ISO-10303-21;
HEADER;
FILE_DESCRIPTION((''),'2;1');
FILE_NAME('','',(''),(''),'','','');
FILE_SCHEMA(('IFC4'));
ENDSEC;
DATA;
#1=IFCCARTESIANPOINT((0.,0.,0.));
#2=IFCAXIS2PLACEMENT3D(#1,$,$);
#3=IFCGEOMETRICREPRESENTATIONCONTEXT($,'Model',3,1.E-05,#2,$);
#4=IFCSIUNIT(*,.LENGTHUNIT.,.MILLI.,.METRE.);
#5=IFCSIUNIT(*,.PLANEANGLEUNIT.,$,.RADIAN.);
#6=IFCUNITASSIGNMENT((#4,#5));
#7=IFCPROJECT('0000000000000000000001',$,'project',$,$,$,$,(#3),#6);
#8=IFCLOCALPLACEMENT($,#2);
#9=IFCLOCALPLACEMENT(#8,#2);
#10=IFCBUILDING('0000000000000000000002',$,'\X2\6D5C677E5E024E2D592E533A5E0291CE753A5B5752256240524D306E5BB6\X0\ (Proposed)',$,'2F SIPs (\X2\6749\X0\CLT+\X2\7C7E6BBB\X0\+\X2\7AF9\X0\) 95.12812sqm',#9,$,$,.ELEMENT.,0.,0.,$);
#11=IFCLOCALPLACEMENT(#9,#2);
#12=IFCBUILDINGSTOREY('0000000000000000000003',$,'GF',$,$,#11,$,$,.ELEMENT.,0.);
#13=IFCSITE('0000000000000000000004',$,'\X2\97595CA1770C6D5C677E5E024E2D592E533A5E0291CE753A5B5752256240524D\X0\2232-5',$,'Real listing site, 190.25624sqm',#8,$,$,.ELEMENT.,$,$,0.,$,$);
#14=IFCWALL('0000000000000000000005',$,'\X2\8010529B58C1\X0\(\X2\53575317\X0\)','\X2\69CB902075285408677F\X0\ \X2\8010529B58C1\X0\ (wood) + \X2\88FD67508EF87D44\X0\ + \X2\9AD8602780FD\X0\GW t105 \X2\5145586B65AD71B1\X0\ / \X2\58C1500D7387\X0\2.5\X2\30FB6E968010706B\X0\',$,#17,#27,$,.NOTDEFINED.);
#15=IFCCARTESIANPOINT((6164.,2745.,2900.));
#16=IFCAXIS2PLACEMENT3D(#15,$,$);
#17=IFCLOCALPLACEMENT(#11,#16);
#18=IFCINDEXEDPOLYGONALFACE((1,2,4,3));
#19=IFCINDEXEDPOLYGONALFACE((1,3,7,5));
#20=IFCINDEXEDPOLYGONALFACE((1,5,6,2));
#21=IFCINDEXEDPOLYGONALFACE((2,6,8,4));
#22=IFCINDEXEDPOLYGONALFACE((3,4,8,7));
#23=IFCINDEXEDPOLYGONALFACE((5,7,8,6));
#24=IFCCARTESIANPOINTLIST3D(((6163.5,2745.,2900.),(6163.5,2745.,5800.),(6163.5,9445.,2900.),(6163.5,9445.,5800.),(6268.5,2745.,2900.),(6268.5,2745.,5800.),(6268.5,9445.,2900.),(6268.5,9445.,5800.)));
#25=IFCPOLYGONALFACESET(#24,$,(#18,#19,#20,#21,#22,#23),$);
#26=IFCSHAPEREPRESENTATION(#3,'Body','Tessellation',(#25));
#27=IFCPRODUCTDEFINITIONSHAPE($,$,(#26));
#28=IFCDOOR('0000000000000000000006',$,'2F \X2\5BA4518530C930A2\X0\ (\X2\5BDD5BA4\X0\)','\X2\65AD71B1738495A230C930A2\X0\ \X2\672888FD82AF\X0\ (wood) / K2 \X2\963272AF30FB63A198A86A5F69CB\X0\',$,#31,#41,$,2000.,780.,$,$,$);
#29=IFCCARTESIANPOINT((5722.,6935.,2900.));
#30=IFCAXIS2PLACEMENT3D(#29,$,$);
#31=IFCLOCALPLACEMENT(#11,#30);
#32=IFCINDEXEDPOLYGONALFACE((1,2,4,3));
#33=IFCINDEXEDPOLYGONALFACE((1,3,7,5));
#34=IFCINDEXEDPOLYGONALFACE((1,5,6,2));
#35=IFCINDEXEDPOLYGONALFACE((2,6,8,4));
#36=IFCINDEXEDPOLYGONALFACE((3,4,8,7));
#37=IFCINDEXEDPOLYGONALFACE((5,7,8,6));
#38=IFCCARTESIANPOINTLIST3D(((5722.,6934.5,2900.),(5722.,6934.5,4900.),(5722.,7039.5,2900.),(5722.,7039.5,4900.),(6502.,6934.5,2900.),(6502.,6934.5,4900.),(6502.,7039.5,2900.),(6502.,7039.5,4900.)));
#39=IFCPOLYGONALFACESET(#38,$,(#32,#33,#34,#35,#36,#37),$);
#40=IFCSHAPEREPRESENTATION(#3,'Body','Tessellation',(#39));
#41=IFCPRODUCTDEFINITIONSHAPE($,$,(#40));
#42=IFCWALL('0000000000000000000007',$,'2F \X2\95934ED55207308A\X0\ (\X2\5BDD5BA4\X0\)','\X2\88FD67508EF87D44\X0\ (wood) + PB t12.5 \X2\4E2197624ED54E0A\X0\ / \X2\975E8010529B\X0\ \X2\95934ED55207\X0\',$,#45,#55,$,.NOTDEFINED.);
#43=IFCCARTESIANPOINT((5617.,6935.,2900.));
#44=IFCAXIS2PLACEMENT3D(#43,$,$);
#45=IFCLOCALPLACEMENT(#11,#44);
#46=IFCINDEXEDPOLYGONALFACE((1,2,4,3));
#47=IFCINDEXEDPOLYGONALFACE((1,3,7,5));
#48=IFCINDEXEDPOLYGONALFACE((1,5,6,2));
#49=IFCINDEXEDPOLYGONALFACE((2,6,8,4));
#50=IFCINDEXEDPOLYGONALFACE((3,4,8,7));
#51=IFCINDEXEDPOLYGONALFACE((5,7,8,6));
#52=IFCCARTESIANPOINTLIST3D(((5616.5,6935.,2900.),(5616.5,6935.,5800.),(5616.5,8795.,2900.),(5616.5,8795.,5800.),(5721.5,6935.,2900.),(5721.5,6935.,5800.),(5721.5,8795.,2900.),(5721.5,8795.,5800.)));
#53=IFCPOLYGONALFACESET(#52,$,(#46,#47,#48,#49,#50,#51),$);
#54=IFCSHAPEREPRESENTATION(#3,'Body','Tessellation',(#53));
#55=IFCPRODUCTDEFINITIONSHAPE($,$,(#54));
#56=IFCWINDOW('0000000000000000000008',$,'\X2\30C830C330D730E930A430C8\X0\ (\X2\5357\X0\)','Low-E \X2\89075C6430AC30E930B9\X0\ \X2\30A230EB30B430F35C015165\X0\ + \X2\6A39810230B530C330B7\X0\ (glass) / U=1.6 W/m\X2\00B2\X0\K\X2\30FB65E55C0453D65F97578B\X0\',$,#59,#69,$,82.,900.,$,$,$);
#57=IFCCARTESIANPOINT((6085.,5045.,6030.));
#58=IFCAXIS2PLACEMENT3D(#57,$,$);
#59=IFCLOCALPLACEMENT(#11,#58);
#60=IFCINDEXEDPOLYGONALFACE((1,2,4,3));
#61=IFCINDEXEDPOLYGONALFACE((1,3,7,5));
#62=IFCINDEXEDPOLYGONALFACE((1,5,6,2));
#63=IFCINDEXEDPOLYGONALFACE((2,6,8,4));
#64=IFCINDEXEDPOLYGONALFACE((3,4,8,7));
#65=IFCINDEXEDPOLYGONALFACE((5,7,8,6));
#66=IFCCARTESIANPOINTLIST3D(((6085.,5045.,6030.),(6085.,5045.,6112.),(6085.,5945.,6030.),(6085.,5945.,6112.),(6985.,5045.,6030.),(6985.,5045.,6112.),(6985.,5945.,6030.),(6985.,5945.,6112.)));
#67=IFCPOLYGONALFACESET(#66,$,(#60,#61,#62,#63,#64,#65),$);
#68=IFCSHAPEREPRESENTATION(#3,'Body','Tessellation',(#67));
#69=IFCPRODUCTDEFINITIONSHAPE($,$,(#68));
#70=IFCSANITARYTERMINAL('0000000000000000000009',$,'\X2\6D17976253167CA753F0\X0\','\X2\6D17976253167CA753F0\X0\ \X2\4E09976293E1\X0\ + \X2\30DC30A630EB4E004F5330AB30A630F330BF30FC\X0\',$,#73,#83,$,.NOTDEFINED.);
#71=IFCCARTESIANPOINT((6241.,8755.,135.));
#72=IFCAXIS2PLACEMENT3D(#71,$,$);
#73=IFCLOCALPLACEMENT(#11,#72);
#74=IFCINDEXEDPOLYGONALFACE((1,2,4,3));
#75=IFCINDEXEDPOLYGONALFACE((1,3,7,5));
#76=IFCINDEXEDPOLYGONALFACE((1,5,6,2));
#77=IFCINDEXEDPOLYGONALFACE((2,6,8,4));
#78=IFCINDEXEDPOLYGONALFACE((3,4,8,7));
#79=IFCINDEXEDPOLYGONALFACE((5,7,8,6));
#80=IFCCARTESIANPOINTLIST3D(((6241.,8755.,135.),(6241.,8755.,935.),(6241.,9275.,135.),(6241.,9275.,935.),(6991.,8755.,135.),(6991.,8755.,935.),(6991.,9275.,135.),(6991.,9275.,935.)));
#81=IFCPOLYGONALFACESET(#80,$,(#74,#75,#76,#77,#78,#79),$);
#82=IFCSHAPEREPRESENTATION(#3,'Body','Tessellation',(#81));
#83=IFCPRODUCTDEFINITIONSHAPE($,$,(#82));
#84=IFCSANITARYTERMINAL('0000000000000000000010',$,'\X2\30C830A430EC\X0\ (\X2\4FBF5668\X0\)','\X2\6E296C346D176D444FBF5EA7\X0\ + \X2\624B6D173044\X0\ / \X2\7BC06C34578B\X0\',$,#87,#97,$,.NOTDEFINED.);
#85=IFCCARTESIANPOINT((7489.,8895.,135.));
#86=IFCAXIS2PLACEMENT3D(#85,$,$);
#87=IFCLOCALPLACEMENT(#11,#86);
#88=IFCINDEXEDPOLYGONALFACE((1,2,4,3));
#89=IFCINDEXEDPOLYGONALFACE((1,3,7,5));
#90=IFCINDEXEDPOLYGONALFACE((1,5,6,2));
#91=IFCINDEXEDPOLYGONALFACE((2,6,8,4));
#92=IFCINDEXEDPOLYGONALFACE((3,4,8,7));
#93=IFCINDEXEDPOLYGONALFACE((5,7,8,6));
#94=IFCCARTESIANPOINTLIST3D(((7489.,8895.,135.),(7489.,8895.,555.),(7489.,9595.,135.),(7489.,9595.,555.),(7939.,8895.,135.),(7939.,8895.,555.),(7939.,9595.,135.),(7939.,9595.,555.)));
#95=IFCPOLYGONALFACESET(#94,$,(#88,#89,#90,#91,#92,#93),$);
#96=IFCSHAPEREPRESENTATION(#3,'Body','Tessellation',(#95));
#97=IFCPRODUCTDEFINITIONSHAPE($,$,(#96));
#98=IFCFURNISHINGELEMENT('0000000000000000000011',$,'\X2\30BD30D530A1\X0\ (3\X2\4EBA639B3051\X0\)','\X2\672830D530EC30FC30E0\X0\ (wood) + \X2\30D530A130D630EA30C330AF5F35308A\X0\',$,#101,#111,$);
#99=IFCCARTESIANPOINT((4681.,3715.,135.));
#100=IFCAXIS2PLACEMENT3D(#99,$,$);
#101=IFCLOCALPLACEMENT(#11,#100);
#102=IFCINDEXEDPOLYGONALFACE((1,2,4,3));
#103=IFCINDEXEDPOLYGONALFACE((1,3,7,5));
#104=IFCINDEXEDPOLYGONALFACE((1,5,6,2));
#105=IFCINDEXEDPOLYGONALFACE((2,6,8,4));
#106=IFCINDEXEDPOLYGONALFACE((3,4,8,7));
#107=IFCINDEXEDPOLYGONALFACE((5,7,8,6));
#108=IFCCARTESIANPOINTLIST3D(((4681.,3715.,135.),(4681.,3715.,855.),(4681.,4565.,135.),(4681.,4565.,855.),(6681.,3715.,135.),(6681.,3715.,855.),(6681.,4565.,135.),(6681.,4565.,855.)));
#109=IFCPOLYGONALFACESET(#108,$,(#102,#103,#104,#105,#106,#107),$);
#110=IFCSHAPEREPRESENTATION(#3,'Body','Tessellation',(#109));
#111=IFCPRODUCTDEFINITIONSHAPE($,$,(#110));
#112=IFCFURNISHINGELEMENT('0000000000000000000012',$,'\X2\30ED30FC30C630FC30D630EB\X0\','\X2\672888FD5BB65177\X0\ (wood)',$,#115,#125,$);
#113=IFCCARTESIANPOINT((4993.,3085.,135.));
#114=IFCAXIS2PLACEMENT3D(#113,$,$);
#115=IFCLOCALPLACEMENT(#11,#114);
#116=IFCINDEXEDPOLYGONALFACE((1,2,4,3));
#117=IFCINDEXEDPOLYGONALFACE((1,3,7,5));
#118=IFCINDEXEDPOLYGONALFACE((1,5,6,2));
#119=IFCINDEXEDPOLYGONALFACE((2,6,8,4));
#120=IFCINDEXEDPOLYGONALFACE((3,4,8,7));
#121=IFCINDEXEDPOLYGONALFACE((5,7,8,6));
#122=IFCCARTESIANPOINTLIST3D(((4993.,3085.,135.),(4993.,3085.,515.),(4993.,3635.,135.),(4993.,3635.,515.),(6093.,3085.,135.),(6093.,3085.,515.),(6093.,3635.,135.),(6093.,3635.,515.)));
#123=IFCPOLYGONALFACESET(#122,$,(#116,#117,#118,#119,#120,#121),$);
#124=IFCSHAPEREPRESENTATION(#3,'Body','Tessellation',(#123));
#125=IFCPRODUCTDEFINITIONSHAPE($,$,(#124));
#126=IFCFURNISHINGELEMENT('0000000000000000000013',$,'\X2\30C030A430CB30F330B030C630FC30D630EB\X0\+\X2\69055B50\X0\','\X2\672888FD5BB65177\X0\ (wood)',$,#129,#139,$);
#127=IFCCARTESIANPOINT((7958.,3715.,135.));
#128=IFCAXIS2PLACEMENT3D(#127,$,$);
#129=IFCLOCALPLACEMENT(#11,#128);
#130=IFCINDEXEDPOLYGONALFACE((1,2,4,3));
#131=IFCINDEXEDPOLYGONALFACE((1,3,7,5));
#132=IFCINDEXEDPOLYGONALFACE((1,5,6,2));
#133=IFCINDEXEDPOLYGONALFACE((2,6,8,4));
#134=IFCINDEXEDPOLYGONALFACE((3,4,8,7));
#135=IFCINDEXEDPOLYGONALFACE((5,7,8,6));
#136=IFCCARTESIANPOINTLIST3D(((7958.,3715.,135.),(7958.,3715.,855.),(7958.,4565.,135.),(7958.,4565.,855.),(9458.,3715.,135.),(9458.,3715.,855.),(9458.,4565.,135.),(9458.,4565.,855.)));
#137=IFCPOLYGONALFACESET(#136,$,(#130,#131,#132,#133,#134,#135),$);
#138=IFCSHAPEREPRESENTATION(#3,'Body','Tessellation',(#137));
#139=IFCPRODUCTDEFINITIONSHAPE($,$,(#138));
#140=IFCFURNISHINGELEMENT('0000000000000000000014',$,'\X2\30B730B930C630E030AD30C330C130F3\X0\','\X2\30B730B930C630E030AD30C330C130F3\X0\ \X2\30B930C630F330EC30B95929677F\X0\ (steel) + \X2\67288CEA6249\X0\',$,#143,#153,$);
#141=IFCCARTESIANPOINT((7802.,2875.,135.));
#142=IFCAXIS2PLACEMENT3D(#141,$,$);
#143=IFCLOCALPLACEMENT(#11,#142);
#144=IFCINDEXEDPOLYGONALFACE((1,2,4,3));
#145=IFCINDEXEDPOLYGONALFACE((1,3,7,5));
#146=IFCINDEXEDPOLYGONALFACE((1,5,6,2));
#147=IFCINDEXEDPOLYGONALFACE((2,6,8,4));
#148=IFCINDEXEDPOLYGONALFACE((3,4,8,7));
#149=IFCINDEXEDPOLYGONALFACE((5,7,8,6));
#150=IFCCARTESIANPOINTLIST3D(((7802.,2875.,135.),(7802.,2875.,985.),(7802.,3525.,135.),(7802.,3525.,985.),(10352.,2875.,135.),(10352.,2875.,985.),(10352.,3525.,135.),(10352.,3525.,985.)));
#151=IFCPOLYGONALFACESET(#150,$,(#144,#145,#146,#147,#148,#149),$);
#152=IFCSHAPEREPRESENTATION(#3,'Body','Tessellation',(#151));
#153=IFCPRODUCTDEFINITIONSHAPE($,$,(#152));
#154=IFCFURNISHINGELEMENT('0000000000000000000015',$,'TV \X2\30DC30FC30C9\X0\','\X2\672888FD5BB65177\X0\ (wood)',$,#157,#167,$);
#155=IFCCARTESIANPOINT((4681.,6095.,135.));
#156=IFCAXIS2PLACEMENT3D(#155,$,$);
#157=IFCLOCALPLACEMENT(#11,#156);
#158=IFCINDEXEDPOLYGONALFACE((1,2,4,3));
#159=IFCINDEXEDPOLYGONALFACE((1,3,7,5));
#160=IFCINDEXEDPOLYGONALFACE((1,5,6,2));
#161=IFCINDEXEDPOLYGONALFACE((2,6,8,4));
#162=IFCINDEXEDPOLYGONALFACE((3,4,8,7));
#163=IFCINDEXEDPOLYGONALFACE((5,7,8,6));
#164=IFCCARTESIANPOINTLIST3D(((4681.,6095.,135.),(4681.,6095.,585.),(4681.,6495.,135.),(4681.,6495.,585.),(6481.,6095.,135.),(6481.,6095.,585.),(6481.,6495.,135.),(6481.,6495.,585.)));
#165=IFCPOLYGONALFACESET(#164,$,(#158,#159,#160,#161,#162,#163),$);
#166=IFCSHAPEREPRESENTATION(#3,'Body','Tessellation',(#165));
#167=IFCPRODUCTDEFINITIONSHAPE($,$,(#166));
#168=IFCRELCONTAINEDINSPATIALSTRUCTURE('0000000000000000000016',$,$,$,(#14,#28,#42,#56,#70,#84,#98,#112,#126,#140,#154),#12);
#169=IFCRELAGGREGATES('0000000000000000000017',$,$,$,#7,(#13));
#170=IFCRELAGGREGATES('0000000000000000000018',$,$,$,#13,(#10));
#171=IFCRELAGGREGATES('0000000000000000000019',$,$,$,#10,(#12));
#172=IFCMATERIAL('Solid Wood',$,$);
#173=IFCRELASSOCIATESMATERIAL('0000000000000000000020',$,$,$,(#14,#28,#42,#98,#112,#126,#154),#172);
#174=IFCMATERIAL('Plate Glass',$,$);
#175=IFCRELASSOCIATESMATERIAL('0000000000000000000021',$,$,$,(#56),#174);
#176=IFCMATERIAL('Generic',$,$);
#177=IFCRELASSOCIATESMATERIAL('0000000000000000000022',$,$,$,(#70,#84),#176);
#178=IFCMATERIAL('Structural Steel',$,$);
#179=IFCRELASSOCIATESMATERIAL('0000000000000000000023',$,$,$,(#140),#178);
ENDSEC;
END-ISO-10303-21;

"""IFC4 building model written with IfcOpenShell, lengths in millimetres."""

from ifc_helpers import new_model, si_unit, frame, frame_2d, origin, place, context, project, spatial, rectangle, extrude, material, element, fill, save


model = new_model("IFC4")

# Units and contexts
model_context = context("Model", 3, precision=1e-05, world=origin())
ifc_project = project(units=[si_unit("LENGTHUNIT", "METRE", prefix="MILLI"), si_unit("PLANEANGLEUNIT", "RADIAN")], contexts=[model_context])

# Site, building, storey
site_placement = place(None, origin())
site = spatial("IfcSite", under=ifc_project, at=site_placement, Name="静岡県浜松市中央区市野町字別所前2232-5", ObjectType="Real listing site, 190.25624sqm", CompositionType="ELEMENT", RefElevation=0.0)
building_placement = place(site_placement, origin())
building = spatial("IfcBuilding", under=site, at=building_placement, Name="浜松市中央区市野町字別所前の家 (Proposed)", ObjectType="2F SIPs (杉CLT+籾殻+竹) 95.12812sqm", CompositionType="ELEMENT", ElevationOfRefHeight=0.0, ElevationOfTerrain=0.0)
storey_placement = place(building_placement, origin())
storey = spatial("IfcBuildingStorey", under=building, at=storey_placement, Name="GF", CompositionType="ELEMENT", Elevation=0.0)

# Shared definitions
ifc_material_1 = material(Name="Solid Wood")

# Wall, opening, door
wall_1_placement = place(storey_placement, frame((6164.0, 2745.0, 2900.0)))
wall_1 = element("IfcWall", 1, at=wall_1_placement, inside=storey, material=ifc_material_1, Name="耐力壁(南北)", Description="構造用合板 耐力壁 (wood) + 製材軸組 + 高性能GW t105 充填断熱 / 壁倍率2.5・準耐火", PredefinedType="NOTDEFINED", context=model_context, shape_type="SweptSolid", body=[
    extrude(rectangle(XDim=105.0, YDim=6700.0, at=frame_2d((52.0, 3350.0))), frame((6164.0, 2745.0, 2900.0)), (0.0, 0.0, 1.0), 2900.0),
])
opening_1_placement = place(storey_placement, frame((5722.0, 6935.0, 2900.0)))
opening_1 = element("IfcOpeningElement", 2, at=opening_1_placement, cuts=wall_1, PredefinedType="NOTDEFINED", context=model_context, shape_type="SweptSolid", body=[
    extrude(rectangle(XDim=780.0, YDim=105.0, at=frame_2d((390.0, 52.0))), frame((5722.0, 6935.0, 2900.0)), (0.0, 0.0, 1.0), 2000.0),
])
door_1_placement = place(storey_placement, frame((5722.0, 6935.0, 2900.0)))
door_1 = element("IfcDoor", 3, at=door_1_placement, inside=storey, material=ifc_material_1, Name="2F 室内ドア (寝室)", Description="断熱玄関ドア 木製芯 (wood) / K2 防犯・採風機構", OverallHeight=2000.0, OverallWidth=780.0, context=model_context, shape_type="SweptSolid", body=[
    extrude(rectangle(XDim=780.0, YDim=105.0, at=frame_2d((390.0, 52.0))), frame((5722.0, 6935.0, 2900.0)), (0.0, 0.0, 1.0), 2000.0),
])
fill(opening_1, door_1)

# Wall
wall_2_placement = place(storey_placement, frame((5617.0, 6935.0, 2900.0)))
element("IfcWall", 4, at=wall_2_placement, inside=storey, material=ifc_material_1, Name="2F 間仕切り (寝室)", Description="製材軸組 (wood) + PB t12.5 両面仕上 / 非耐力 間仕切", PredefinedType="NOTDEFINED", context=model_context, shape_type="SweptSolid", body=[
    extrude(rectangle(XDim=105.0, YDim=1860.0, at=frame_2d((52.0, 930.0))), frame((5617.0, 6935.0, 2900.0)), (0.0, 0.0, 1.0), 2900.0),
])

# Window
ifc_material_2 = material(Name="Plate Glass")
window_placement = place(storey_placement, frame((6085.0, 5045.0, 6030.0)))
element("IfcWindow", 5, at=window_placement, inside=storey, material=ifc_material_2, Name="トップライト (南)", Description="Low-E 複層ガラス アルゴン封入 + 樹脂サッシ (glass) / U=1.6 W/m²K・日射取得型", OverallHeight=82.0, OverallWidth=900.0, context=model_context, shape_type="SweptSolid", body=[
    extrude(rectangle(XDim=900.0, YDim=900.0, at=frame_2d((450.0, 450.0))), frame((6085.0, 5045.0, 6030.0)), (0.0, 0.0, 1.0), 82.0),
])

# Sanitary terminals
ifc_material_3 = material(Name="Generic")
sanitary_terminal_1_placement = place(storey_placement, frame((6241.0, 8755.0, 135.0)))
element("IfcSanitaryTerminal", 6, at=sanitary_terminal_1_placement, inside=storey, material=ifc_material_3, Name="洗面化粧台", Description="洗面化粧台 三面鏡 + ボウル一体カウンター", PredefinedType="NOTDEFINED", context=model_context, shape_type="SweptSolid", body=[
    extrude(rectangle(XDim=750.0, YDim=520.0, at=frame_2d((375.0, 260.0))), frame((6241.0, 8755.0, 135.0)), (0.0, 0.0, 1.0), 800.0),
])
sanitary_terminal_2_placement = place(storey_placement, frame((7489.0, 8895.0, 135.0)))
element("IfcSanitaryTerminal", 7, at=sanitary_terminal_2_placement, inside=storey, material=ifc_material_3, Name="トイレ (便器)", Description="温水洗浄便座 + 手洗い / 節水型", PredefinedType="NOTDEFINED", context=model_context, shape_type="SweptSolid", body=[
    extrude(rectangle(XDim=450.0, YDim=700.0, at=frame_2d((225.0, 350.0))), frame((7489.0, 8895.0, 135.0)), (0.0, 0.0, 1.0), 420.0),
])

# Furnishing elements
furnishing_1_placement = place(storey_placement, frame((4681.0, 3715.0, 135.0)))
element("IfcFurnishingElement", 8, at=furnishing_1_placement, inside=storey, material=ifc_material_1, Name="ソファ (3人掛け)", Description="木フレーム (wood) + ファブリック張り", context=model_context, shape_type="SweptSolid", body=[
    extrude(rectangle(XDim=2000.0, YDim=850.0, at=frame_2d((1000.0, 425.0))), frame((4681.0, 3715.0, 135.0)), (0.0, 0.0, 1.0), 720.0),
])
furnishing_2_placement = place(storey_placement, frame((4993.0, 3085.0, 135.0)))
element("IfcFurnishingElement", 9, at=furnishing_2_placement, inside=storey, material=ifc_material_1, Name="ローテーブル", Description="木製家具 (wood)", context=model_context, shape_type="SweptSolid", body=[
    extrude(rectangle(XDim=1100.0, YDim=550.0, at=frame_2d((550.0, 275.0))), frame((4993.0, 3085.0, 135.0)), (0.0, 0.0, 1.0), 380.0),
])
furnishing_3_placement = place(storey_placement, frame((7958.0, 3715.0, 135.0)))
element("IfcFurnishingElement", 10, at=furnishing_3_placement, inside=storey, material=ifc_material_1, Name="ダイニングテーブル+椅子", Description="木製家具 (wood)", context=model_context, shape_type="SweptSolid", body=[
    extrude(rectangle(XDim=1500.0, YDim=850.0, at=frame_2d((750.0, 425.0))), frame((7958.0, 3715.0, 135.0)), (0.0, 0.0, 1.0), 720.0),
])
ifc_material_4 = material(Name="Structural Steel")
furnishing_4_placement = place(storey_placement, frame((7802.0, 2875.0, 135.0)))
element("IfcFurnishingElement", 11, at=furnishing_4_placement, inside=storey, material=ifc_material_4, Name="システムキッチン", Description="システムキッチン ステンレス天板 (steel) + 木質扉", context=model_context, shape_type="SweptSolid", body=[
    extrude(rectangle(XDim=2550.0, YDim=650.0, at=frame_2d((1275.0, 325.0))), frame((7802.0, 2875.0, 135.0)), (0.0, 0.0, 1.0), 850.0),
])
furnishing_5_placement = place(storey_placement, frame((4681.0, 6095.0, 135.0)))
element("IfcFurnishingElement", 12, at=furnishing_5_placement, inside=storey, material=ifc_material_1, Name="TV ボード", Description="木製家具 (wood)", context=model_context, shape_type="SweptSolid", body=[
    extrude(rectangle(XDim=1800.0, YDim=400.0, at=frame_2d((900.0, 200.0))), frame((4681.0, 6095.0, 135.0)), (0.0, 0.0, 1.0), 450.0),
])

save(model, "model.ifc")
